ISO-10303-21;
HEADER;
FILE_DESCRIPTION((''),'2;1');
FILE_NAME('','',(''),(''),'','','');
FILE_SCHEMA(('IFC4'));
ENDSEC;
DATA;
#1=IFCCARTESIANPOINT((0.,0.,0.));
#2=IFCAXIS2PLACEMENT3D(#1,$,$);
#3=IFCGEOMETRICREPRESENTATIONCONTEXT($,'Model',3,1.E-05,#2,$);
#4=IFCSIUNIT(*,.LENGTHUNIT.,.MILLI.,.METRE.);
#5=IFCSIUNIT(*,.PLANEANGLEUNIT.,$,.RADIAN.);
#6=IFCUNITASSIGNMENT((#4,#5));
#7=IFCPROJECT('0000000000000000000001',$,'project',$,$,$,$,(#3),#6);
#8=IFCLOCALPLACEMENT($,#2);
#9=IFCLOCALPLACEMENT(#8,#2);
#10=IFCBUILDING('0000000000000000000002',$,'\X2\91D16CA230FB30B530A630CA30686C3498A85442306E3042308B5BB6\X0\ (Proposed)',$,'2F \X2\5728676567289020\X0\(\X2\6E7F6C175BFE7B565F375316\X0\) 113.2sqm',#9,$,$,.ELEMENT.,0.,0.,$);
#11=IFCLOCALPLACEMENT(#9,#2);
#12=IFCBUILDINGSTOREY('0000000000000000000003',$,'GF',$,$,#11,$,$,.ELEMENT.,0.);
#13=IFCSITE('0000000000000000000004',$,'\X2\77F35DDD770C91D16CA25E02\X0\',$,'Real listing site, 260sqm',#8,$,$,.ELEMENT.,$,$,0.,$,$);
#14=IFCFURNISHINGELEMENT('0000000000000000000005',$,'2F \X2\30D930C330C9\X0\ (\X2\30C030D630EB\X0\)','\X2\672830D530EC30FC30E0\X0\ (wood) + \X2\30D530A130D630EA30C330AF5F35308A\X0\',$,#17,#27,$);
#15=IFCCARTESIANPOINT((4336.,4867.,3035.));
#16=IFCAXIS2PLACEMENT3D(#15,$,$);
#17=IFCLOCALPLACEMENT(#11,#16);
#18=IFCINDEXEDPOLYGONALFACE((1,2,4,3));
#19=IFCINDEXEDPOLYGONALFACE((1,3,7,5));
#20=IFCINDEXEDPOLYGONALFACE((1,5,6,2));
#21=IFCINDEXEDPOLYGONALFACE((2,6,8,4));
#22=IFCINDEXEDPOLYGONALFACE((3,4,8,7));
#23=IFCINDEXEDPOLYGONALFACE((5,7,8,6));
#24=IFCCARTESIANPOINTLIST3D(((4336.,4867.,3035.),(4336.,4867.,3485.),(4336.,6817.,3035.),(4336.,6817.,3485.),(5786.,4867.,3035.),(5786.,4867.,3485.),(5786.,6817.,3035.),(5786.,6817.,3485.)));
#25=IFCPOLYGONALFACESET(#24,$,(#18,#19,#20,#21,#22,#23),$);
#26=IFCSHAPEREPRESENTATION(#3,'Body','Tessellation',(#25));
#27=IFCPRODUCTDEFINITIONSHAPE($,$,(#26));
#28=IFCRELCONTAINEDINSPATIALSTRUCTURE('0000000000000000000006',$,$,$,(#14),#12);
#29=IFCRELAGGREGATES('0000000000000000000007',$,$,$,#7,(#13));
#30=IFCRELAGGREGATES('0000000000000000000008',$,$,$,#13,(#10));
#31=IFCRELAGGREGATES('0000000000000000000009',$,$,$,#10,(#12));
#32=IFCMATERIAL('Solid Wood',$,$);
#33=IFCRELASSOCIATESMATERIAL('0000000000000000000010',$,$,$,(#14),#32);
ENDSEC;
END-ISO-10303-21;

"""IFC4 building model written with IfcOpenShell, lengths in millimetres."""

from ifc_helpers import new_model, si_unit, frame, frame_2d, origin, place, context, project, spatial, rectangle, extrude, material, element, save


model = new_model("IFC4")

# Units and contexts
model_context = context("Model", 3, precision=1e-05, world=origin())
ifc_project = project(units=[si_unit("LENGTHUNIT", "METRE", prefix="MILLI"), si_unit("PLANEANGLEUNIT", "RADIAN")], contexts=[model_context])

# Site, building, storey
site_placement = place(None, origin())
site = spatial("IfcSite", under=ifc_project, at=site_placement, Name="石川県金沢市", ObjectType="Real listing site, 260sqm", CompositionType="ELEMENT", RefElevation=0.0)
building_placement = place(site_placement, origin())
building = spatial("IfcBuilding", under=site, at=building_placement, Name="金沢・サウナと水風呂のある家 (Proposed)", ObjectType="2F 在来木造(湿気対策強化) 113.2sqm", CompositionType="ELEMENT", ElevationOfRefHeight=0.0, ElevationOfTerrain=0.0)
storey_placement = place(building_placement, origin())
storey = spatial("IfcBuildingStorey", under=building, at=storey_placement, Name="GF", CompositionType="ELEMENT", Elevation=0.0)

# Shared definitions
ifc_material_1 = material(Name="Solid Wood")

# Furnishing element
furnishing_1_placement = place(storey_placement, frame((4336.0, 4867.0, 3035.0)))
element("IfcFurnishingElement", 1, at=furnishing_1_placement, inside=storey, material=ifc_material_1, Name="2F ベッド (ダブル)", Description="木フレーム (wood) + ファブリック張り", context=model_context, shape_type="SweptSolid", body=[
    extrude(rectangle(XDim=1450.0, YDim=1950.0, at=frame_2d((725.0, 975.0))), frame((4336.0, 4867.0, 3035.0)), (0.0, 0.0, 1.0), 450.0),
])

save(model, "model.ifc")
